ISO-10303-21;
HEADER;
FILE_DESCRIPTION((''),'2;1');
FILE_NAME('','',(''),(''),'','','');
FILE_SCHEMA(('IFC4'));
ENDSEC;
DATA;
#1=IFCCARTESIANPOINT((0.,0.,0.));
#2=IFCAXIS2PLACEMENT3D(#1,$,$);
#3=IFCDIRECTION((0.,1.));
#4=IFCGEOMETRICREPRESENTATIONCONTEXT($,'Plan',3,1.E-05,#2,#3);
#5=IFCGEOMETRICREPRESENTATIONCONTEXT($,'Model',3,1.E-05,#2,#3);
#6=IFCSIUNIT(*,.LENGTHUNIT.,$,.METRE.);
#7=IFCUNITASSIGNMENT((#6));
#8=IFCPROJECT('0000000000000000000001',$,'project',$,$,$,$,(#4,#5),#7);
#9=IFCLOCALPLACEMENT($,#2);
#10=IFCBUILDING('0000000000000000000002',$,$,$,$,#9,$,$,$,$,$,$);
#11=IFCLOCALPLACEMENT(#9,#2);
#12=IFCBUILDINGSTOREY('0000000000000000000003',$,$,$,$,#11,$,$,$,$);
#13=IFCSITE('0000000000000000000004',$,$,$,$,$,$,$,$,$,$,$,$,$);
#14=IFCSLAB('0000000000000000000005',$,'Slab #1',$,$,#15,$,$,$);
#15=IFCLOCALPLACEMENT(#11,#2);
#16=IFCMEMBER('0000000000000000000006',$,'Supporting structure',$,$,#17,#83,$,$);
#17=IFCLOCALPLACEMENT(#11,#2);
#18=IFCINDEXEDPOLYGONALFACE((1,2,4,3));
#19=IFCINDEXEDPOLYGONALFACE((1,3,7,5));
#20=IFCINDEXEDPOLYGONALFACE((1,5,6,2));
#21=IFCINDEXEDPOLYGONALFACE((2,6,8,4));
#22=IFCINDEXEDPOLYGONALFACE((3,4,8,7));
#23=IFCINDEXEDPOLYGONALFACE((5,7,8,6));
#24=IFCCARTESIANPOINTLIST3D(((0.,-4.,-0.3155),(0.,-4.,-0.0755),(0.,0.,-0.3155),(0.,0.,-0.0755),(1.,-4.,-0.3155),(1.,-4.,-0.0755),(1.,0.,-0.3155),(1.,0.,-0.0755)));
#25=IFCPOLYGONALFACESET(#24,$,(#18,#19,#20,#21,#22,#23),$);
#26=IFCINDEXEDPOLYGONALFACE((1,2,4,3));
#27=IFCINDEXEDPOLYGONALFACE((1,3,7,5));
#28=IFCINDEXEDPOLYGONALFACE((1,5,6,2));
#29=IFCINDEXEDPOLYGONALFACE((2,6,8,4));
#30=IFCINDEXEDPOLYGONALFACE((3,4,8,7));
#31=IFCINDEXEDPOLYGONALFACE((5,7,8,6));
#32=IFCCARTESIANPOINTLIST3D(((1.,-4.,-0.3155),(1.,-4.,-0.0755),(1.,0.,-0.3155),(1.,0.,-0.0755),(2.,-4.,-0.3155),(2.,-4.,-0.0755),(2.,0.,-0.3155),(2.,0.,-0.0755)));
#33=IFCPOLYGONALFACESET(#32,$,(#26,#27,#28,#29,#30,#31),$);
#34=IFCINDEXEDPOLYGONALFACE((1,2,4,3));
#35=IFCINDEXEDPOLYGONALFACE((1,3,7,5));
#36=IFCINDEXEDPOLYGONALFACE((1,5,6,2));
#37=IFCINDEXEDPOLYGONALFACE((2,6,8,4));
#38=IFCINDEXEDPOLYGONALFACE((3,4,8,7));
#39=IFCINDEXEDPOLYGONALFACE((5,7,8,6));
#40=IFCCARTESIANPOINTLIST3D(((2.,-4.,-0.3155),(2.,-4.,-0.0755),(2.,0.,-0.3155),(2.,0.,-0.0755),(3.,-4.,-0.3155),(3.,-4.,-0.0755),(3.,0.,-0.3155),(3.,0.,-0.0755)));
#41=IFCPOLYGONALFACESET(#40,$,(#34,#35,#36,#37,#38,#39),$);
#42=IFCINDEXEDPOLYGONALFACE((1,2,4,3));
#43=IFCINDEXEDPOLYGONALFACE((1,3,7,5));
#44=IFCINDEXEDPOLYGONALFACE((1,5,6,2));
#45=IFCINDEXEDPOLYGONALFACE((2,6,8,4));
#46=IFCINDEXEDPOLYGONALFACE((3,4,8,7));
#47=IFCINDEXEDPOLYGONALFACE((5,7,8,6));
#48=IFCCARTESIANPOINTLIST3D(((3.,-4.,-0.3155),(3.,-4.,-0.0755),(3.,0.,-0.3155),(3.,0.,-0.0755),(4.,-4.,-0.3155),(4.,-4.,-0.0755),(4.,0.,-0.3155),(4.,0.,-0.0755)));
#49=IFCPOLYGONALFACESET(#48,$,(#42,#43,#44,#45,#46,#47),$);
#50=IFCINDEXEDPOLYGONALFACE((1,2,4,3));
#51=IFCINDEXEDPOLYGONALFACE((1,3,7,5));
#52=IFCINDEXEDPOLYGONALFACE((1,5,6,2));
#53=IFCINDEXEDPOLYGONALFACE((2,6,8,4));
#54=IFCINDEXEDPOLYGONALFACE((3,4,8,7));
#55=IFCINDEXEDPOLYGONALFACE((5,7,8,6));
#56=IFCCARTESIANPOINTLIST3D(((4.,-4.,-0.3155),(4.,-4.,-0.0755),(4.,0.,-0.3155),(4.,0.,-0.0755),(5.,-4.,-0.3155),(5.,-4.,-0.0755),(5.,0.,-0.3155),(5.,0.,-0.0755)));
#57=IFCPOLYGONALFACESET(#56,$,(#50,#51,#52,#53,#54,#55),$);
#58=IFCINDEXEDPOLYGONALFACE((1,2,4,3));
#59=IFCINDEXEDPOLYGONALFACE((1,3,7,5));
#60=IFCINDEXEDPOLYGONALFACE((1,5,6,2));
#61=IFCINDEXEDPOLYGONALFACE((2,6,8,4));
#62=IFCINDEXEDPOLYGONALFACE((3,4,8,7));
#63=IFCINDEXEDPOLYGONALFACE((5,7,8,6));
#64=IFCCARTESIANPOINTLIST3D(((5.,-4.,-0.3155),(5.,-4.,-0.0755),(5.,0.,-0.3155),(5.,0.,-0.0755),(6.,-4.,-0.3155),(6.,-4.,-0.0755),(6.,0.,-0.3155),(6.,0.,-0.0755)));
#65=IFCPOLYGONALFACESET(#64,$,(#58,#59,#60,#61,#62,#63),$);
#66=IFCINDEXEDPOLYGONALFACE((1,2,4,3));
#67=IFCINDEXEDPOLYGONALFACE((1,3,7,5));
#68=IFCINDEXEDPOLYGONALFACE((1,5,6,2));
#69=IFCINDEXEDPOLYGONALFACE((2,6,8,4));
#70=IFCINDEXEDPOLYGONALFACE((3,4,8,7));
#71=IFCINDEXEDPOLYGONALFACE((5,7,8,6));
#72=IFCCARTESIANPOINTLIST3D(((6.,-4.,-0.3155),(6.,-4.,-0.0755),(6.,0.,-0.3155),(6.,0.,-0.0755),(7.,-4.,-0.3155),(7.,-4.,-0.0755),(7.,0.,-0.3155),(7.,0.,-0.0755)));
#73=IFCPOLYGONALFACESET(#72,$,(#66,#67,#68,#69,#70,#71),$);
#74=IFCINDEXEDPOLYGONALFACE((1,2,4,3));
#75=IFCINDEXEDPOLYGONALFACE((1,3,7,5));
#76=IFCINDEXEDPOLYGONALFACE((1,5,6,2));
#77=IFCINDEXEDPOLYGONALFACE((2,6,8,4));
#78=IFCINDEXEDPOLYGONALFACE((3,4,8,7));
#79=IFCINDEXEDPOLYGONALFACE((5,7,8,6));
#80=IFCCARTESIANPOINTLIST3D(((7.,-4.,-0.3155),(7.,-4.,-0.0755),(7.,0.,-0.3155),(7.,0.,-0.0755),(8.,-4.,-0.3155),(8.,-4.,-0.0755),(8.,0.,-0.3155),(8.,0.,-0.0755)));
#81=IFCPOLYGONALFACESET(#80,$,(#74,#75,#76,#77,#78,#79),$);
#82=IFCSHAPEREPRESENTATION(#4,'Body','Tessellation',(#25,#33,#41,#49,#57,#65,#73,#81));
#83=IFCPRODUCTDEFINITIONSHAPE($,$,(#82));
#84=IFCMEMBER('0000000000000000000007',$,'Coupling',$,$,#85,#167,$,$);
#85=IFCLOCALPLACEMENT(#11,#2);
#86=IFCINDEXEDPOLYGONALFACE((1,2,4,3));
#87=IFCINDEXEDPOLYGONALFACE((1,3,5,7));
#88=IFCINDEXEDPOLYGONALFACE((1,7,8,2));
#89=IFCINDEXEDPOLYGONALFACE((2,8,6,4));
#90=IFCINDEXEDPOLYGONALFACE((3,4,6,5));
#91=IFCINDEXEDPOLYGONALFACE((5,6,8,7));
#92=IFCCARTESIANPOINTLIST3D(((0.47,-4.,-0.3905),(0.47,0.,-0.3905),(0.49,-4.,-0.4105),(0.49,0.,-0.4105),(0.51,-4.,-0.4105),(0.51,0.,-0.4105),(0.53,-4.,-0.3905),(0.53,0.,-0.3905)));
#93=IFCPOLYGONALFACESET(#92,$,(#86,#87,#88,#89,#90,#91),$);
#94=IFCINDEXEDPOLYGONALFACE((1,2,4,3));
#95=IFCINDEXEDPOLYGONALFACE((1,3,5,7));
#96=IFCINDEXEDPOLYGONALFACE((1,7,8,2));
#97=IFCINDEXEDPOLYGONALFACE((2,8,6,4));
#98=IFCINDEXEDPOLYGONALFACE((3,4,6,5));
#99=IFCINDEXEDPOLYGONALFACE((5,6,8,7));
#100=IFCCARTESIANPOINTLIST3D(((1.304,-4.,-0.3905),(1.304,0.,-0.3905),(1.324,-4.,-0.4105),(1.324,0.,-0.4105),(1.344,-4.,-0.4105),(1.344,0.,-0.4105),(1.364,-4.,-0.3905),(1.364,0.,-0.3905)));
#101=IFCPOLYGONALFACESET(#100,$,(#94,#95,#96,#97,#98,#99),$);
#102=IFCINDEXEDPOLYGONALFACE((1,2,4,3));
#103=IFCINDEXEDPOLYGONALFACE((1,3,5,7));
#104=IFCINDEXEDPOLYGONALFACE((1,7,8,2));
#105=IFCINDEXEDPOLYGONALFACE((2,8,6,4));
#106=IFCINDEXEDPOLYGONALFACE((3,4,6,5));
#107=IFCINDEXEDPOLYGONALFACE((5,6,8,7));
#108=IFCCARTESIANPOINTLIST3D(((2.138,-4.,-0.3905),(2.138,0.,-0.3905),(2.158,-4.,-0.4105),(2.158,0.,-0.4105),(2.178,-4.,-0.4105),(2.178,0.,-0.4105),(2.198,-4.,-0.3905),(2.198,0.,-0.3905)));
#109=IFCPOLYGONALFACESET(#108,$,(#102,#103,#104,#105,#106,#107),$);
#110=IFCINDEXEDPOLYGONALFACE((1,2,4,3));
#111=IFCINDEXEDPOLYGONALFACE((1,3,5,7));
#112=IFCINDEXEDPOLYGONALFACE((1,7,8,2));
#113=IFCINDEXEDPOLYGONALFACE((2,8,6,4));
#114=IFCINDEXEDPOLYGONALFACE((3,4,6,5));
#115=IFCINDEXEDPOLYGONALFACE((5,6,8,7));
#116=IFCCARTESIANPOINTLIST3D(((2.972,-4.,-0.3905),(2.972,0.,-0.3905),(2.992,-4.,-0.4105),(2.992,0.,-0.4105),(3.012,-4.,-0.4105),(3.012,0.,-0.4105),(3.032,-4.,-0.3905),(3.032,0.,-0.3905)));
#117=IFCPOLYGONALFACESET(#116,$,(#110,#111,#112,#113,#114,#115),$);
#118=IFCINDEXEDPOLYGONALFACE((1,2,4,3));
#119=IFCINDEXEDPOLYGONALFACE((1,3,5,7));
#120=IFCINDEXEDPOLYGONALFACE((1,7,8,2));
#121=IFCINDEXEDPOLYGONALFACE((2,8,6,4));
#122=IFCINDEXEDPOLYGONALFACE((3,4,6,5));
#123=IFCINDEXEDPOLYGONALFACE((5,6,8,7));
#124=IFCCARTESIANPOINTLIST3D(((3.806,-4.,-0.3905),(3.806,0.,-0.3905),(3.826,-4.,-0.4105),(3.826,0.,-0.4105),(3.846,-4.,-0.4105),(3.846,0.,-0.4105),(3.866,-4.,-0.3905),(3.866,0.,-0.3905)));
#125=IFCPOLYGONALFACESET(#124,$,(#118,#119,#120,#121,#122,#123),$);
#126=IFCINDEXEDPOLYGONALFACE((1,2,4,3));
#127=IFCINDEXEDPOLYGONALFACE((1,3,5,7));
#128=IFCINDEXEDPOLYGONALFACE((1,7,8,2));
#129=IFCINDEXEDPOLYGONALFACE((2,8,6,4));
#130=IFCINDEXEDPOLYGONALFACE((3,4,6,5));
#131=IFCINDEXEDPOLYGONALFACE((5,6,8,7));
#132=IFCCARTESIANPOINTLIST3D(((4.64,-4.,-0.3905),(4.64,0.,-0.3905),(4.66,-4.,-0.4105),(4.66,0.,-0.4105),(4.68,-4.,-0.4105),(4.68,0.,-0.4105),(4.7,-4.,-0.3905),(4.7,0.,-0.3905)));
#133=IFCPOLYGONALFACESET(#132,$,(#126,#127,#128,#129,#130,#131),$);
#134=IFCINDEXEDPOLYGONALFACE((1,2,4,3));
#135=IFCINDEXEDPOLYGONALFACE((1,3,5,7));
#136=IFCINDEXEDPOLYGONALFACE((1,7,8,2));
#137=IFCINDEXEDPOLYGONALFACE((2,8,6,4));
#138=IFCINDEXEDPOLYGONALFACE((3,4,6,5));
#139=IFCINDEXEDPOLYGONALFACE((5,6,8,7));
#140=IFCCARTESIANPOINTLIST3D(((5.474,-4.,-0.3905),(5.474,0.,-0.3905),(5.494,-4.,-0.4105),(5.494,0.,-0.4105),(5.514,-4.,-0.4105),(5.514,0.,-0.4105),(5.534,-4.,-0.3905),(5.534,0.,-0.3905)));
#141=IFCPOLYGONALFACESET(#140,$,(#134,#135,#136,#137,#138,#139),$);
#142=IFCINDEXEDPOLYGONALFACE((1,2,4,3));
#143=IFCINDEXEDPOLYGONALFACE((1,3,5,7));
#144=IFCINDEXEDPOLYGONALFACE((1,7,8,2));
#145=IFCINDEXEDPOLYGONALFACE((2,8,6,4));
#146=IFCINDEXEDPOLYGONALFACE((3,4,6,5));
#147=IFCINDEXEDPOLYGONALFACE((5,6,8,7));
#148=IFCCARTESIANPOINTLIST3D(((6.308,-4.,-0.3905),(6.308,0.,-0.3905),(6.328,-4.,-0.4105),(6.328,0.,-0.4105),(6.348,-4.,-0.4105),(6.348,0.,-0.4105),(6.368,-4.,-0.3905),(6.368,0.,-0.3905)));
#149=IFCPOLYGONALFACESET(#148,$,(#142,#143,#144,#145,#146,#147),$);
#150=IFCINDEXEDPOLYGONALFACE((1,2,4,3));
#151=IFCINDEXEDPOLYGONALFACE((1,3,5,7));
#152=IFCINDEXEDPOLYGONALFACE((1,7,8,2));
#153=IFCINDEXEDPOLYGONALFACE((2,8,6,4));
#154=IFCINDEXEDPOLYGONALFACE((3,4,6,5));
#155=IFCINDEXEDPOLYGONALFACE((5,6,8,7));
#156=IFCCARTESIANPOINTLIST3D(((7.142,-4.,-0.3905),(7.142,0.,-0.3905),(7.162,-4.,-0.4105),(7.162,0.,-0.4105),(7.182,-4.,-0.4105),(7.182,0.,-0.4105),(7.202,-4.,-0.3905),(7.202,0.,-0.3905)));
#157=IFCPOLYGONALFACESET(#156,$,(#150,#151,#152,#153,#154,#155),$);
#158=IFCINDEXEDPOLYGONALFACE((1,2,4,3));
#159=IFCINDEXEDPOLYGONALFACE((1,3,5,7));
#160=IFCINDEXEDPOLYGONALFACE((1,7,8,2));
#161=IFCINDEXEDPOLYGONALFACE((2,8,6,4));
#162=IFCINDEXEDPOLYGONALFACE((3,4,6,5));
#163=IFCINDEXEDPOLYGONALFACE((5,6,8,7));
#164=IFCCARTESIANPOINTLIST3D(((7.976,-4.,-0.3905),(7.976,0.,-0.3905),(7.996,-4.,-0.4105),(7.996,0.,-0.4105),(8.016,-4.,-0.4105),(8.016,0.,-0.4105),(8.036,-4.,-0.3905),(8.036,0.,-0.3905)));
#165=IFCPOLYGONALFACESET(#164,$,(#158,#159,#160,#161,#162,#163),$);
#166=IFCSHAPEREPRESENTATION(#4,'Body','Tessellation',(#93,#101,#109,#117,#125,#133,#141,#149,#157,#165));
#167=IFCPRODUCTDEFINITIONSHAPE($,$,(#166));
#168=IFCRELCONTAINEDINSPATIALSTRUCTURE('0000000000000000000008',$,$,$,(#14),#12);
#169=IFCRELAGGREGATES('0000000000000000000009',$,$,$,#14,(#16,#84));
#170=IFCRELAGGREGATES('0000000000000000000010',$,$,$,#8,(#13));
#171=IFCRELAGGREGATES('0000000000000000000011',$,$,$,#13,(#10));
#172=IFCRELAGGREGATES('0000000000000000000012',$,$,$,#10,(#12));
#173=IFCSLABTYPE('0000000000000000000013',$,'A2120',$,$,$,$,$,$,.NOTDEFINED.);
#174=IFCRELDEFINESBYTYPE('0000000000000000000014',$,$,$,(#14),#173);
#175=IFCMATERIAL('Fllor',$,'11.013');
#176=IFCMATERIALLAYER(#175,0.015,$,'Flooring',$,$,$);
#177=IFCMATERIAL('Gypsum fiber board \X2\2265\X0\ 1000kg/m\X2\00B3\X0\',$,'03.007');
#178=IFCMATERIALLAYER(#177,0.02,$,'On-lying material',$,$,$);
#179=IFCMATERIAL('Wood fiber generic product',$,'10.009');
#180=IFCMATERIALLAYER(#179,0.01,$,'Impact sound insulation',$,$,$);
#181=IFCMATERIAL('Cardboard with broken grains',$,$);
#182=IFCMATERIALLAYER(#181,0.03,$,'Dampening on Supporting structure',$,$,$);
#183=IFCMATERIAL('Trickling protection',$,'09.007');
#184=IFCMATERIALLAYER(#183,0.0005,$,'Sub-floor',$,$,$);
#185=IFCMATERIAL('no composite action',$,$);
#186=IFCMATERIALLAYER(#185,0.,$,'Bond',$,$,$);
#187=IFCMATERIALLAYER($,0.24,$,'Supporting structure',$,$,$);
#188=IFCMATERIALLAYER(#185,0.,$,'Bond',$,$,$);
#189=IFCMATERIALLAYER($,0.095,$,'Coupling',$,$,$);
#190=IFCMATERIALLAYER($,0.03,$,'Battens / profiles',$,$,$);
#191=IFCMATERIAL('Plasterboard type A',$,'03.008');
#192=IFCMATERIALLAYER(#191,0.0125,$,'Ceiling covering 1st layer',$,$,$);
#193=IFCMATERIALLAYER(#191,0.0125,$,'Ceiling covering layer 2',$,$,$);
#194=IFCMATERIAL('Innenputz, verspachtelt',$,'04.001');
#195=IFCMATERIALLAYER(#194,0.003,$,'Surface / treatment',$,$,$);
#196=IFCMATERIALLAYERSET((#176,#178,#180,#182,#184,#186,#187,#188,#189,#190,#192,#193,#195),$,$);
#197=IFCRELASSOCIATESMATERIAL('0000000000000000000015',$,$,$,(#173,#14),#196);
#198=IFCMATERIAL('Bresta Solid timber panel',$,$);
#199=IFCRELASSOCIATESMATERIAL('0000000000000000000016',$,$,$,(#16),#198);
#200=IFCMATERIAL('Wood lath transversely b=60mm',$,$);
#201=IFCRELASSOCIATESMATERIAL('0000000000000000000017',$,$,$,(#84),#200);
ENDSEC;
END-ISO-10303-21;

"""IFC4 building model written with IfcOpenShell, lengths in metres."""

from ifc_helpers import new_model, si_unit, direction, frame, frame_2d, origin, place, context, project, spatial, polyline, rectangle, outline, extrude, material, layer, layer_set, type_object, element, aggregate, save


model = new_model("IFC4")

# Units and contexts
plan_context = context("Plan", 3, precision=1e-05, world=origin(), true_north=direction((0.0, 1.0)))
model_context = context("Model", 3, precision=1e-05, world=origin(), true_north=direction((0.0, 1.0)))
ifc_project = project(units=[si_unit("LENGTHUNIT", "METRE")], contexts=[plan_context, model_context])

# Site, building, storey
site = spatial("IfcSite", under=ifc_project)
building_placement = place(None, origin())
building = spatial("IfcBuilding", under=site, at=building_placement)
storey_placement = place(building_placement, origin())
storey = spatial("IfcBuildingStorey", under=building, at=storey_placement)

# Slab, members
ifc_material_1 = material(Name="Fllor", Category="11.013")
ifc_layer_1 = layer(ifc_material_1, 0.015, Name="Flooring")
ifc_material_2 = material(Name="Gypsum fiber board ≥ 1000kg/m³", Category="03.007")
ifc_layer_2 = layer(ifc_material_2, 0.02, Name="On-lying material")
ifc_material_3 = material(Name="Wood fiber generic product", Category="10.009")
ifc_layer_3 = layer(ifc_material_3, 0.01, Name="Impact sound insulation")
ifc_material_4 = material(Name="Cardboard with broken grains")
ifc_layer_4 = layer(ifc_material_4, 0.03, Name="Dampening on Supporting structure")
ifc_material_5 = material(Name="Trickling protection", Category="09.007")
ifc_layer_5 = layer(ifc_material_5, 0.0005, Name="Sub-floor")
ifc_material_6 = material(Name="no composite action")
ifc_layer_6 = layer(ifc_material_6, 0.0, Name="Bond")
ifc_layer_7 = layer(None, 0.24, Name="Supporting structure")
ifc_layer_8 = layer(ifc_material_6, 0.0, Name="Bond")
ifc_layer_9 = layer(None, 0.095, Name="Coupling")
ifc_layer_10 = layer(None, 0.03, Name="Battens / profiles")
ifc_material_7 = material(Name="Plasterboard type A", Category="03.008")
ifc_layer_11 = layer(ifc_material_7, 0.0125, Name="Ceiling covering 1st layer")
ifc_layer_12 = layer(ifc_material_7, 0.0125, Name="Ceiling covering layer 2")
ifc_material_8 = material(Name="Innenputz, verspachtelt", Category="04.001")
ifc_layer_13 = layer(ifc_material_8, 0.003, Name="Surface / treatment")
ifc_layer_set = layer_set([ifc_layer_1, ifc_layer_2, ifc_layer_3, ifc_layer_4, ifc_layer_5, ifc_layer_6, ifc_layer_7, ifc_layer_8, ifc_layer_9, ifc_layer_10, ifc_layer_11, ifc_layer_12, ifc_layer_13])
slab_type = type_object("IfcSlabType", Name="A2120", PredefinedType="NOTDEFINED", material=ifc_layer_set)
slab_placement = place(None, frame((0.0, 0.0, 0.0), z_axis=(0.0, 0.0, -1.0), x_axis=(1.0, 0.0, 0.0)))
slab = element("IfcSlab", 1, at=slab_placement, inside=storey, type_object=slab_type, material=ifc_layer_set, Name="Slab #1")
ifc_material_9 = material(Name="Bresta Solid timber panel")
member_1_placement = place(slab_placement, origin())
member_1 = element("IfcMember", 2, at=member_1_placement, material=ifc_material_9, Name="Supporting structure", context=plan_context, shape_type="SweptSolid", body=[
    extrude(rectangle(XDim=1.0, YDim=0.24, at=frame_2d((0.5, 0.12), x_axis=(1.0, 0.0))), frame((0.0, 4.0, 0.0755), z_axis=(0.0, -1.0, 0.0), x_axis=(1.0, 0.0, 0.0)), (0.0, 0.0, 1.0), 4.0),
    extrude(rectangle(XDim=1.0, YDim=0.24, at=frame_2d((0.5, 0.12), x_axis=(1.0, 0.0))), frame((1.0, 4.0, 0.0755), z_axis=(0.0, -1.0, 0.0), x_axis=(1.0, 0.0, 0.0)), (0.0, 0.0, 1.0), 4.0),
    extrude(rectangle(XDim=1.0, YDim=0.24, at=frame_2d((0.5, 0.12), x_axis=(1.0, 0.0))), frame((2.0, 4.0, 0.0755), z_axis=(0.0, -1.0, 0.0), x_axis=(1.0, 0.0, 0.0)), (0.0, 0.0, 1.0), 4.0),
    extrude(rectangle(XDim=1.0, YDim=0.24, at=frame_2d((0.5, 0.12), x_axis=(1.0, 0.0))), frame((3.0, 4.0, 0.0755), z_axis=(0.0, -1.0, 0.0), x_axis=(1.0, 0.0, 0.0)), (0.0, 0.0, 1.0), 4.0),
    extrude(rectangle(XDim=1.0, YDim=0.24, at=frame_2d((0.5, 0.12), x_axis=(1.0, 0.0))), frame((4.0, 4.0, 0.0755), z_axis=(0.0, -1.0, 0.0), x_axis=(1.0, 0.0, 0.0)), (0.0, 0.0, 1.0), 4.0),
    extrude(rectangle(XDim=1.0, YDim=0.24, at=frame_2d((0.5, 0.12), x_axis=(1.0, 0.0))), frame((5.0, 4.0, 0.0755), z_axis=(0.0, -1.0, 0.0), x_axis=(1.0, 0.0, 0.0)), (0.0, 0.0, 1.0), 4.0),
    extrude(rectangle(XDim=1.0, YDim=0.24, at=frame_2d((0.5, 0.12), x_axis=(1.0, 0.0))), frame((6.0, 4.0, 0.0755), z_axis=(0.0, -1.0, 0.0), x_axis=(1.0, 0.0, 0.0)), (0.0, 0.0, 1.0), 4.0),
    extrude(rectangle(XDim=1.0, YDim=0.24, at=frame_2d((0.5, 0.12), x_axis=(1.0, 0.0))), frame((7.0, 4.0, 0.0755), z_axis=(0.0, -1.0, 0.0), x_axis=(1.0, 0.0, 0.0)), (0.0, 0.0, 1.0), 4.0),
])
ifc_material_10 = material(Name="Wood lath transversely b=60mm")
member_2_placement = place(slab_placement, origin())
member_2 = element("IfcMember", 3, at=member_2_placement, material=ifc_material_10, Name="Coupling", context=plan_context, shape_type="SweptSolid", body=[
    extrude(outline(polyline([(0.0, 0.0), (0.06, 0.0), (0.04, 0.02), (0.02, 0.02), (0.0, 0.0)])), frame((0.47, 4.0, 0.3905), z_axis=(0.0, -1.0, 0.0), x_axis=(1.0, 0.0, 0.0)), (0.0, 0.0, 1.0), 4.0),
    extrude(outline(polyline([(0.0, 0.0), (0.06, 0.0), (0.04, 0.02), (0.02, 0.02), (0.0, 0.0)])), frame((1.304, 4.0, 0.3905), z_axis=(0.0, -1.0, 0.0), x_axis=(1.0, 0.0, 0.0)), (0.0, 0.0, 1.0), 4.0),
    extrude(outline(polyline([(0.0, 0.0), (0.06, 0.0), (0.04, 0.02), (0.02, 0.02), (0.0, 0.0)])), frame((2.138, 4.0, 0.3905), z_axis=(0.0, -1.0, 0.0), x_axis=(1.0, 0.0, 0.0)), (0.0, 0.0, 1.0), 4.0),
    extrude(outline(polyline([(0.0, 0.0), (0.06, 0.0), (0.04, 0.02), (0.02, 0.02), (0.0, 0.0)])), frame((2.972, 4.0, 0.3905), z_axis=(0.0, -1.0, 0.0), x_axis=(1.0, 0.0, 0.0)), (0.0, 0.0, 1.0), 4.0),
    extrude(outline(polyline([(0.0, 0.0), (0.06, 0.0), (0.04, 0.02), (0.02, 0.02), (0.0, 0.0)])), frame((3.806, 4.0, 0.3905), z_axis=(0.0, -1.0, 0.0), x_axis=(1.0, 0.0, 0.0)), (0.0, 0.0, 1.0), 4.0),
    extrude(outline(polyline([(0.0, 0.0), (0.06, 0.0), (0.04, 0.02), (0.02, 0.02), (0.0, 0.0)])), frame((4.64, 4.0, 0.3905), z_axis=(0.0, -1.0, 0.0), x_axis=(1.0, 0.0, 0.0)), (0.0, 0.0, 1.0), 4.0),
    extrude(outline(polyline([(0.0, 0.0), (0.06, 0.0), (0.04, 0.02), (0.02, 0.02), (0.0, 0.0)])), frame((5.474, 4.0, 0.3905), z_axis=(0.0, -1.0, 0.0), x_axis=(1.0, 0.0, 0.0)), (0.0, 0.0, 1.0), 4.0),
    extrude(outline(polyline([(0.0, 0.0), (0.06, 0.0), (0.04, 0.02), (0.02, 0.02), (0.0, 0.0)])), frame((6.308, 4.0, 0.3905), z_axis=(0.0, -1.0, 0.0), x_axis=(1.0, 0.0, 0.0)), (0.0, 0.0, 1.0), 4.0),
    extrude(outline(polyline([(0.0, 0.0), (0.06, 0.0), (0.04, 0.02), (0.02, 0.02), (0.0, 0.0)])), frame((7.142, 4.0, 0.3905), z_axis=(0.0, -1.0, 0.0), x_axis=(1.0, 0.0, 0.0)), (0.0, 0.0, 1.0), 4.0),
    extrude(outline(polyline([(0.0, 0.0), (0.06, 0.0), (0.04, 0.02), (0.02, 0.02), (0.0, 0.0)])), frame((7.976, 4.0, 0.3905), z_axis=(0.0, -1.0, 0.0), x_axis=(1.0, 0.0, 0.0)), (0.0, 0.0, 1.0), 4.0),
])
aggregate(slab, [member_1, member_2])

save(model, "model.ifc")
